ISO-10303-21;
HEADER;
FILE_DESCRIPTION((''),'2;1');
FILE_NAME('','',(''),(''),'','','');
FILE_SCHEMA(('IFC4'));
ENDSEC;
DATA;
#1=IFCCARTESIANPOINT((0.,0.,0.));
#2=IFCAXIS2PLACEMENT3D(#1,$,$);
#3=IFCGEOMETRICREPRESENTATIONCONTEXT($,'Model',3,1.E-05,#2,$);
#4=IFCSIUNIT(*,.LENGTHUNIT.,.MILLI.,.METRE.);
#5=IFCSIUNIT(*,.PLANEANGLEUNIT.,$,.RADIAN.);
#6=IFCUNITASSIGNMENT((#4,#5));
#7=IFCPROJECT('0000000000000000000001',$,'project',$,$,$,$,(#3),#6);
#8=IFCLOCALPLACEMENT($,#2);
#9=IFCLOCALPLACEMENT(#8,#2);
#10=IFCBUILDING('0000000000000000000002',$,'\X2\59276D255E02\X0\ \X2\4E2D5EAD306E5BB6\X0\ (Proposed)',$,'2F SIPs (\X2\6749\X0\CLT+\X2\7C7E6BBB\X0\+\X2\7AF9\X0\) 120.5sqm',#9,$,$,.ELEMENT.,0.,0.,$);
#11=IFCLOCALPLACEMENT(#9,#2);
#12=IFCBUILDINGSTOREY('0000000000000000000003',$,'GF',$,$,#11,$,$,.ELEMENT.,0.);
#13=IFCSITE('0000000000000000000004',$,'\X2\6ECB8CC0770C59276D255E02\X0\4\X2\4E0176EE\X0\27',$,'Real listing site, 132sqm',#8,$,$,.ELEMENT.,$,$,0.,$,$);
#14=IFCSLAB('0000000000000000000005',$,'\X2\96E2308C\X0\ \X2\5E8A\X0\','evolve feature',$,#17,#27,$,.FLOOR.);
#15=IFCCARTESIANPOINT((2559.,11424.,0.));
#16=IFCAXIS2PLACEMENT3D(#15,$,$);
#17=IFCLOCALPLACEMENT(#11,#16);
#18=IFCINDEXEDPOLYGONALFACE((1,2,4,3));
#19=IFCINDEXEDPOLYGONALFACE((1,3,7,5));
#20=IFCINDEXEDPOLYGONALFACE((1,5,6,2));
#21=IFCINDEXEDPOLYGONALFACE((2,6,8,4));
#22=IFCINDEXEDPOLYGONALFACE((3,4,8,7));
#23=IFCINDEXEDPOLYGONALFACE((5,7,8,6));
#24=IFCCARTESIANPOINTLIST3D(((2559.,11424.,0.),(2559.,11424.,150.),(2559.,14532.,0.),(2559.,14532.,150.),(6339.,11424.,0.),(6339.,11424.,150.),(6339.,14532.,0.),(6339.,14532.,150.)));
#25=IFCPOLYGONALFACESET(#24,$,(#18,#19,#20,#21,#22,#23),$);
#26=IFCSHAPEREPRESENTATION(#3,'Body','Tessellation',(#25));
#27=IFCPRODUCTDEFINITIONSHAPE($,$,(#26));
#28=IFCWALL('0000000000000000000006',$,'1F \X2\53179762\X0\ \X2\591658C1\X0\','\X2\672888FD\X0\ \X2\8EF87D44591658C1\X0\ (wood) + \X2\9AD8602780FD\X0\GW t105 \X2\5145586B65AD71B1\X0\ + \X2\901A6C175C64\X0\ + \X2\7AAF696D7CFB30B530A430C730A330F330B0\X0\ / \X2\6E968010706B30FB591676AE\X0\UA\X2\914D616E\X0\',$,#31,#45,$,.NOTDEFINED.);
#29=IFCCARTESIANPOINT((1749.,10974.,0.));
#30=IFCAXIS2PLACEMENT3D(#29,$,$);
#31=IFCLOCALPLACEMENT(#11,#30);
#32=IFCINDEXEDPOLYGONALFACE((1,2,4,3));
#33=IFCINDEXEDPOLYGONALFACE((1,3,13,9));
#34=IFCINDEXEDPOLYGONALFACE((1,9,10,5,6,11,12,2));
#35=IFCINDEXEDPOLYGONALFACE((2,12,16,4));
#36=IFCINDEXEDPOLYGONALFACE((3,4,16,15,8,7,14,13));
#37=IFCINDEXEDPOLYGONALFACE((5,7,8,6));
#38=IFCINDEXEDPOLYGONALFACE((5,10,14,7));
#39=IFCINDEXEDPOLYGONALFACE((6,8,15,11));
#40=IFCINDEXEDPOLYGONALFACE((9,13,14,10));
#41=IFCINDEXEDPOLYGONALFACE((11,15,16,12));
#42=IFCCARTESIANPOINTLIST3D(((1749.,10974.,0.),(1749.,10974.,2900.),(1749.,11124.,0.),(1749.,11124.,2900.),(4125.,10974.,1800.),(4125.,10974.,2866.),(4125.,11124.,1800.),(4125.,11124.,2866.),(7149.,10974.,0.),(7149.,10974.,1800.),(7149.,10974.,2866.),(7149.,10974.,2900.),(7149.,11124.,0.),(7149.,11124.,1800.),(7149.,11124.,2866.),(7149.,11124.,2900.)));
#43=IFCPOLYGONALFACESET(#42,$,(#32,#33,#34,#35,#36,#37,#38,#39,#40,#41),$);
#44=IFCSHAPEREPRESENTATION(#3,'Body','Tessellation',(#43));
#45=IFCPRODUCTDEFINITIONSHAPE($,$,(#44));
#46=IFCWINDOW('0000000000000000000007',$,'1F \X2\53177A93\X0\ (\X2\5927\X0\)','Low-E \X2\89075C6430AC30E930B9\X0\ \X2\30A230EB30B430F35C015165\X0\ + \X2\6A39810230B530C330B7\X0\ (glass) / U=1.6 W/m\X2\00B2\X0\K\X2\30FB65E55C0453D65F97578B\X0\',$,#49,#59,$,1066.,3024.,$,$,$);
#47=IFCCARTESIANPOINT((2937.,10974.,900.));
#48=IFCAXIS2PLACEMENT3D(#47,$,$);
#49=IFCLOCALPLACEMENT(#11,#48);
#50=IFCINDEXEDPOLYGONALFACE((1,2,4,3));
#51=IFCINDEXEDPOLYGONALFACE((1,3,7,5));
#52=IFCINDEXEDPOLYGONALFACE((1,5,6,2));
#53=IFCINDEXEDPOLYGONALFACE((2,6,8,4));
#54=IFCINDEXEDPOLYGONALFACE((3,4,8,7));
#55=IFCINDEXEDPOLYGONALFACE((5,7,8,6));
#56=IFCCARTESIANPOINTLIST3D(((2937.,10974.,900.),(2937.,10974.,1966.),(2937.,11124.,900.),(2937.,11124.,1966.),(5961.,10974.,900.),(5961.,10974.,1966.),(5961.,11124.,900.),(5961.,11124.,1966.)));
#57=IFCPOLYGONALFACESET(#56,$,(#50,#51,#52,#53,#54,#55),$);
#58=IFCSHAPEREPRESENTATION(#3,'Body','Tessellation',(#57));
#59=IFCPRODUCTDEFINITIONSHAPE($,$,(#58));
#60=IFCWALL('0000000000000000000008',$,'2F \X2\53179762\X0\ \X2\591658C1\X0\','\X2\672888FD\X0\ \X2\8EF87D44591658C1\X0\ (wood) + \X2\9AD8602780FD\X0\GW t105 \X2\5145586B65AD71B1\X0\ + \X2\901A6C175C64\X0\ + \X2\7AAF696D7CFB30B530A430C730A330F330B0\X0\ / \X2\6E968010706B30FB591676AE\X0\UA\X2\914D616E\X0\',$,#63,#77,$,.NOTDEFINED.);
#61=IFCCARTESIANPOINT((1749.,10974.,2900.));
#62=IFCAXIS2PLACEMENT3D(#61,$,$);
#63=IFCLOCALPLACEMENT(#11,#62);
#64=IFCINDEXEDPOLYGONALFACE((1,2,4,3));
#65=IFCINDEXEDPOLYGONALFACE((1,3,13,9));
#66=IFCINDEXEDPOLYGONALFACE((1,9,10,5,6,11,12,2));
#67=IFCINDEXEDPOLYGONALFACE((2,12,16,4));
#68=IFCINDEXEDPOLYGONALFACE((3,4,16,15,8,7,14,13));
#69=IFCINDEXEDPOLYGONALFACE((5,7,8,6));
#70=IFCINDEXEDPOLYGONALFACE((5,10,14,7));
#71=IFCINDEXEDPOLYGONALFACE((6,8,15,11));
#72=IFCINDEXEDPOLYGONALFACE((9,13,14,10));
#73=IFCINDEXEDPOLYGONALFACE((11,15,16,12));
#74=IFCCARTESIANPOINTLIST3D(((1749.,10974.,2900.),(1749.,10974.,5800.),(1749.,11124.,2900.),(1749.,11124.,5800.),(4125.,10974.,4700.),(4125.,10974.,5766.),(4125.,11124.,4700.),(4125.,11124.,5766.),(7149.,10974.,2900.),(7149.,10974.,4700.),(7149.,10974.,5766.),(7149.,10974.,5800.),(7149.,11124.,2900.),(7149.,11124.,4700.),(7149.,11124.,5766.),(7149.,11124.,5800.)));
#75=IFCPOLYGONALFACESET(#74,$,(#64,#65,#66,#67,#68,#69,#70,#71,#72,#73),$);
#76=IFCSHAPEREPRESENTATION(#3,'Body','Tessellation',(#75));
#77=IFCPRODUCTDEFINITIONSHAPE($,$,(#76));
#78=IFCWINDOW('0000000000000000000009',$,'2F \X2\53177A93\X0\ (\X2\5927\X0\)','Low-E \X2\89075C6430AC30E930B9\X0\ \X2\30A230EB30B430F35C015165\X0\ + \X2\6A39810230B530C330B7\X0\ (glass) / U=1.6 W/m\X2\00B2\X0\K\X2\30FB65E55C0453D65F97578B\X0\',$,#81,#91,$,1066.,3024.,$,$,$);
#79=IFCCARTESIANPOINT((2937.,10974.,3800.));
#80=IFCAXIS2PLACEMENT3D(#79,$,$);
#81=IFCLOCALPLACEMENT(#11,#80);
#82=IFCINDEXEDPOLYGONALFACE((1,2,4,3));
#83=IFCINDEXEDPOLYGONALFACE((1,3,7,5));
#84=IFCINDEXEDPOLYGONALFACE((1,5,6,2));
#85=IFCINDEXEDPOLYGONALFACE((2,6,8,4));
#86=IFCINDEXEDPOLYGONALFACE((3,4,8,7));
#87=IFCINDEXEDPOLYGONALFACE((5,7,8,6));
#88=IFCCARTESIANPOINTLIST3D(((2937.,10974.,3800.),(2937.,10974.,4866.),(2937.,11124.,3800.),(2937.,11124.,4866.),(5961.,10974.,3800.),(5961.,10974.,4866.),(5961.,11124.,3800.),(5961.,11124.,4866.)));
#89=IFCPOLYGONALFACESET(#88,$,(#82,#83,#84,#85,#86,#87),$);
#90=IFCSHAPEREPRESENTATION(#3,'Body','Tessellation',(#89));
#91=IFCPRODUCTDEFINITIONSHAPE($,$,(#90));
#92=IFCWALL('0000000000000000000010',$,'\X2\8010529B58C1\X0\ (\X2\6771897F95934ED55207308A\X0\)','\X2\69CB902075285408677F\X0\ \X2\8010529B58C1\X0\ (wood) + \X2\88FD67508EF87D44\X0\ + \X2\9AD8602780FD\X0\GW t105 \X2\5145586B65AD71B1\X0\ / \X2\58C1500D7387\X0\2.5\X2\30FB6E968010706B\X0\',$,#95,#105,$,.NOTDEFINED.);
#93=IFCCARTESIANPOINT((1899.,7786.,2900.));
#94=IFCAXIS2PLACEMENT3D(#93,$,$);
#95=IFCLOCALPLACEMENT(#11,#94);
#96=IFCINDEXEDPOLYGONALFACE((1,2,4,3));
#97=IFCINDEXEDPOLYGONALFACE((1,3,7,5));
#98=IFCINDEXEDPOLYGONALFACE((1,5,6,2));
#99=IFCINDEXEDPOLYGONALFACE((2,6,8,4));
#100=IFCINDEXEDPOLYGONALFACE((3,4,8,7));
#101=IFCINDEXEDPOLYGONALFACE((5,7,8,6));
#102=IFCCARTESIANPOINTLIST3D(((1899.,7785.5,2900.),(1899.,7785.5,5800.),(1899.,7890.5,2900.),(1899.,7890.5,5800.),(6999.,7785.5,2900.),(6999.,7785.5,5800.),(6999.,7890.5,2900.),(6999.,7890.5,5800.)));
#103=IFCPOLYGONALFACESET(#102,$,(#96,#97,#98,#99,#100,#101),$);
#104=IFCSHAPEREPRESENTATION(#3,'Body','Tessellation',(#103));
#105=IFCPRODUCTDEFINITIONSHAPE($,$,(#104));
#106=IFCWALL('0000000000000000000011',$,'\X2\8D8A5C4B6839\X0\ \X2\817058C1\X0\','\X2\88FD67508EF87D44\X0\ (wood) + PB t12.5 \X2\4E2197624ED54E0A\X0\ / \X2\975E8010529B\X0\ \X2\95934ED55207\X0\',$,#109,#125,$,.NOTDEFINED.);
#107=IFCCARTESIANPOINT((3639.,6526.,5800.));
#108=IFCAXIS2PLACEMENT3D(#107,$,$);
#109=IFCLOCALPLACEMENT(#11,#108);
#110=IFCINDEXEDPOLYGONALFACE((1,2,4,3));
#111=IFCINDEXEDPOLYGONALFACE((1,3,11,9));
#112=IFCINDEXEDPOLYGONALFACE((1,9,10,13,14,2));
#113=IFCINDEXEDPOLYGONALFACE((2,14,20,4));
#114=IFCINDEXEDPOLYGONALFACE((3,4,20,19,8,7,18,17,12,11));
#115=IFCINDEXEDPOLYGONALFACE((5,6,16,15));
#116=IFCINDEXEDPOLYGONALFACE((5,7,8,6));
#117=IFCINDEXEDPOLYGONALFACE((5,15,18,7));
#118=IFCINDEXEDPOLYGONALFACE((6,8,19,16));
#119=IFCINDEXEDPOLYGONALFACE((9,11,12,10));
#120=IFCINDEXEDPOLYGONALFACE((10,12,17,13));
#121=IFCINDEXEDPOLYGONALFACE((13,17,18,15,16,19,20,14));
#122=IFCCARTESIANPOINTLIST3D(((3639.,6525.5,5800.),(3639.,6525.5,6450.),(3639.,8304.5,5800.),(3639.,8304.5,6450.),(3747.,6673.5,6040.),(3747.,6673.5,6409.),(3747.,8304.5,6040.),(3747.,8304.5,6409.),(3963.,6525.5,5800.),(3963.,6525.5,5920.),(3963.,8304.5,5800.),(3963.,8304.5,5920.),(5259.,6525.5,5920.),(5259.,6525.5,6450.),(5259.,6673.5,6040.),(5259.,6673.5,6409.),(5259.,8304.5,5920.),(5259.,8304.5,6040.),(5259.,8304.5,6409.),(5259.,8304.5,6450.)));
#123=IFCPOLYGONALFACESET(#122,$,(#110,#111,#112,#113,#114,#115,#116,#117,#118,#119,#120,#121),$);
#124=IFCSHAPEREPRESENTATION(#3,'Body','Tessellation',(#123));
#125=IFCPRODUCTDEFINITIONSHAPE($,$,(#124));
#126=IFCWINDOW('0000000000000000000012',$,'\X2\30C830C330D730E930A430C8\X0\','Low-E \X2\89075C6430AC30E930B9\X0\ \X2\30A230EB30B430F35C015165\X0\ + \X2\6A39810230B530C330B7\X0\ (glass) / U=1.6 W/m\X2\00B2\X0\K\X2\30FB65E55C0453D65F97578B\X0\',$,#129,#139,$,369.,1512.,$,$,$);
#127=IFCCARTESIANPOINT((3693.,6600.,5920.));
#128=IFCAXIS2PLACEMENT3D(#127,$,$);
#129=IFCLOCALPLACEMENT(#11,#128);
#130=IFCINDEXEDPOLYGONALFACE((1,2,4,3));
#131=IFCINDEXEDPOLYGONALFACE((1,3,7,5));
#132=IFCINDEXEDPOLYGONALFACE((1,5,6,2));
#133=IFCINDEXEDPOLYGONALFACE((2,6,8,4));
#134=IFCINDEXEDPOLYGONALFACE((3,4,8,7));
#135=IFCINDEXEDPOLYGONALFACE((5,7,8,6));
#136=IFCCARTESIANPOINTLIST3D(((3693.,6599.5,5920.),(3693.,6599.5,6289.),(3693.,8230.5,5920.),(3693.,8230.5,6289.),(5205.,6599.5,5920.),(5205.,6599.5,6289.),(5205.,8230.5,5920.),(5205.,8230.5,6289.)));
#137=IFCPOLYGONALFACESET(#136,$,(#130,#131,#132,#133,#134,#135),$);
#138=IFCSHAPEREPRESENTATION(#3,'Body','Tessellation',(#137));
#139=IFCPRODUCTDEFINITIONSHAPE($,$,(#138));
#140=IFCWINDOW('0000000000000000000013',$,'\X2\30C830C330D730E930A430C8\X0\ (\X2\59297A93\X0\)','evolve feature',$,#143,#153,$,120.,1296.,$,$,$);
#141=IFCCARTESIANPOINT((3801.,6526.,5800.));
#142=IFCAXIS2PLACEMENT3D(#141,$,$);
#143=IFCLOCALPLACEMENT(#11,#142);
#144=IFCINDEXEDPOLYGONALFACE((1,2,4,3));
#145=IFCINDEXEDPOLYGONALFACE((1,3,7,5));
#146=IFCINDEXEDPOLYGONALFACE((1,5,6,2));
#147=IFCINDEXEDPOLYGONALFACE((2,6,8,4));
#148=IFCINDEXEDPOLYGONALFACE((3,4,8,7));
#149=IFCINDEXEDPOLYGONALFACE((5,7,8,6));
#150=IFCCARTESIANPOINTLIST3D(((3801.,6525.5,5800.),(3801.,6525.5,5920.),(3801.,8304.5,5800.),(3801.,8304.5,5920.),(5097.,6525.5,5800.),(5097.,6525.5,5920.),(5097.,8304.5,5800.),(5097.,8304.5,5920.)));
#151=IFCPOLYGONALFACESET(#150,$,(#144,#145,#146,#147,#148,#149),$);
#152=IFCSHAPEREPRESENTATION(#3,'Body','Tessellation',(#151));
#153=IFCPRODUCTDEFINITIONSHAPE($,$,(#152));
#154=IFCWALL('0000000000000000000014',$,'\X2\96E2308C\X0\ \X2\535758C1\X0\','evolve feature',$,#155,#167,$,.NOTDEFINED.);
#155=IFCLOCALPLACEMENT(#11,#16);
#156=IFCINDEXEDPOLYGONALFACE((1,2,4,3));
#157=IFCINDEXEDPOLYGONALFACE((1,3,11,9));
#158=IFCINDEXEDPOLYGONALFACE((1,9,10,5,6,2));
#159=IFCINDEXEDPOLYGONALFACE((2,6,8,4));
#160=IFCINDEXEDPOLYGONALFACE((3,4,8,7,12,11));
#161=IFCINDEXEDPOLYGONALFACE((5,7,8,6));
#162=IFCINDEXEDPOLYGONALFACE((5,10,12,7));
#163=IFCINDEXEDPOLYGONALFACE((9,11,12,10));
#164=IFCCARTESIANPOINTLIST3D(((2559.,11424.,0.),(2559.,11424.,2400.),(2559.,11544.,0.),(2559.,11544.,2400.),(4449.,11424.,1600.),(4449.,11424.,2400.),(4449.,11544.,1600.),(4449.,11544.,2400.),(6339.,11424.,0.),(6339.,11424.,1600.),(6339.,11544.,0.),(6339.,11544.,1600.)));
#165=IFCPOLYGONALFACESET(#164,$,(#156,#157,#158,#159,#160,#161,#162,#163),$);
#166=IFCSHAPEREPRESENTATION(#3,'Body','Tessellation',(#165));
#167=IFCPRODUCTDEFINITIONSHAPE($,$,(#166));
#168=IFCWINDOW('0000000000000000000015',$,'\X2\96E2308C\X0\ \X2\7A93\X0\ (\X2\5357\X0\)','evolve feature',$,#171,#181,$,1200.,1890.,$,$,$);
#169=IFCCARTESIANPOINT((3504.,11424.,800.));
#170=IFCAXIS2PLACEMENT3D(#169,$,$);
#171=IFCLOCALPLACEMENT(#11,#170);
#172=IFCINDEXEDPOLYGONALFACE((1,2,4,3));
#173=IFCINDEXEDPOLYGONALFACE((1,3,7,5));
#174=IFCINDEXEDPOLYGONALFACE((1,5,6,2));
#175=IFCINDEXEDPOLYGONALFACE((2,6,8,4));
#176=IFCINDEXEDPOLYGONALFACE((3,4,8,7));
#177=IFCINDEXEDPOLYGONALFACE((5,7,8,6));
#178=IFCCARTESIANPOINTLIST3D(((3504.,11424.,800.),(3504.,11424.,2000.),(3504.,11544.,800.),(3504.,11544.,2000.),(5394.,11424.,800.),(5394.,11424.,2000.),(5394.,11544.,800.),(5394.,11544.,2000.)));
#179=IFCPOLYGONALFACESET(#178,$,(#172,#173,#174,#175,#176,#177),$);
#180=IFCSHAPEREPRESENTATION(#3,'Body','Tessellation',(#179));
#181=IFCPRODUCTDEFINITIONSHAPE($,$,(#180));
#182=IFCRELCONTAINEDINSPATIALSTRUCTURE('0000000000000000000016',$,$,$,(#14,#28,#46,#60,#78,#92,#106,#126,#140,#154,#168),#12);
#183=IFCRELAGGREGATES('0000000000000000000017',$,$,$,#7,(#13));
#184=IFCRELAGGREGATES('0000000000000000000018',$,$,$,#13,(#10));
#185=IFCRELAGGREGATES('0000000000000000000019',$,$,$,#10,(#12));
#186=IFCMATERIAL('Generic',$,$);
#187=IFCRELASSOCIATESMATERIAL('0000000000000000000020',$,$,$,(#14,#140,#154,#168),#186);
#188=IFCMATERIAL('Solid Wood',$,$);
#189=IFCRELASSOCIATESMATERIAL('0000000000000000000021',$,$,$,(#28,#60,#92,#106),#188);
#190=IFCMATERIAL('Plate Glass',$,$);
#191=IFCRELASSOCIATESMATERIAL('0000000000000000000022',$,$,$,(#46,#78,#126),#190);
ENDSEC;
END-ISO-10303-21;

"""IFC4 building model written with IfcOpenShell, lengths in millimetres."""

from ifc_helpers import new_model, si_unit, frame, frame_2d, origin, place, context, project, spatial, rectangle, extrude, material, element, fill, save


model = new_model("IFC4")

# Units and contexts
model_context = context("Model", 3, precision=1e-05, world=origin())
ifc_project = project(units=[si_unit("LENGTHUNIT", "METRE", prefix="MILLI"), si_unit("PLANEANGLEUNIT", "RADIAN")], contexts=[model_context])

# Site, building, storey
site_placement = place(None, origin())
site = spatial("IfcSite", under=ifc_project, at=site_placement, Name="滋賀県大津市4丁目27", ObjectType="Real listing site, 132sqm", CompositionType="ELEMENT", RefElevation=0.0)
building_placement = place(site_placement, origin())
building = spatial("IfcBuilding", under=site, at=building_placement, Name="大津市 中庭の家 (Proposed)", ObjectType="2F SIPs (杉CLT+籾殻+竹) 120.5sqm", CompositionType="ELEMENT", ElevationOfRefHeight=0.0, ElevationOfTerrain=0.0)
storey_placement = place(building_placement, origin())
storey = spatial("IfcBuildingStorey", under=building, at=storey_placement, Name="GF", CompositionType="ELEMENT", Elevation=0.0)

# Slab
ifc_material_1 = material(Name="Generic")
slab_placement = place(storey_placement, frame((2559.0, 11424.0, 0.0)))
element("IfcSlab", 1, at=slab_placement, inside=storey, material=ifc_material_1, Name="離れ 床", Description="evolve feature", PredefinedType="FLOOR", context=model_context, shape_type="SweptSolid", body=[
    extrude(rectangle(XDim=3780.0, YDim=3108.0, at=frame_2d((1890.0, 1554.0))), frame((2559.0, 11424.0, 0.0)), (0.0, 0.0, 1.0), 150.0),
])

# Wall, opening, window
ifc_material_2 = material(Name="Solid Wood")
wall_1_placement = place(storey_placement, frame((1749.0, 10974.0, 0.0)))
wall_1 = element("IfcWall", 2, at=wall_1_placement, inside=storey, material=ifc_material_2, Name="1F 北面 外壁", Description="木製 軸組外壁 (wood) + 高性能GW t105 充填断熱 + 通気層 + 窯業系サイディング / 準耐火・外皮UA配慮", PredefinedType="NOTDEFINED", context=model_context, shape_type="SweptSolid", body=[
    extrude(rectangle(XDim=5400.0, YDim=150.0, at=frame_2d((2700.0, 75.0))), frame((1749.0, 10974.0, 0.0)), (0.0, 0.0, 1.0), 2900.0),
])
opening_1_placement = place(storey_placement, frame((2937.0, 10974.0, 900.0)))
opening_1 = element("IfcOpeningElement", 3, at=opening_1_placement, cuts=wall_1, PredefinedType="NOTDEFINED", context=model_context, shape_type="SweptSolid", body=[
    extrude(rectangle(XDim=3024.0, YDim=150.0, at=frame_2d((1512.0, 75.0))), frame((2937.0, 10974.0, 900.0)), (0.0, 0.0, 1.0), 1066.0),
])
ifc_material_3 = material(Name="Plate Glass")
window_1_placement = place(storey_placement, frame((2937.0, 10974.0, 900.0)))
window_1 = element("IfcWindow", 4, at=window_1_placement, inside=storey, material=ifc_material_3, Name="1F 北窓 (大)", Description="Low-E 複層ガラス アルゴン封入 + 樹脂サッシ (glass) / U=1.6 W/m²K・日射取得型", OverallHeight=1066.0, OverallWidth=3024.0, context=model_context, shape_type="SweptSolid", body=[
    extrude(rectangle(XDim=3024.0, YDim=150.0, at=frame_2d((1512.0, 75.0))), frame((2937.0, 10974.0, 900.0)), (0.0, 0.0, 1.0), 1066.0),
])
fill(opening_1, window_1)

# Wall, opening, window
wall_2_placement = place(storey_placement, frame((1749.0, 10974.0, 2900.0)))
wall_2 = element("IfcWall", 5, at=wall_2_placement, inside=storey, material=ifc_material_2, Name="2F 北面 外壁", Description="木製 軸組外壁 (wood) + 高性能GW t105 充填断熱 + 通気層 + 窯業系サイディング / 準耐火・外皮UA配慮", PredefinedType="NOTDEFINED", context=model_context, shape_type="SweptSolid", body=[
    extrude(rectangle(XDim=5400.0, YDim=150.0, at=frame_2d((2700.0, 75.0))), frame((1749.0, 10974.0, 2900.0)), (0.0, 0.0, 1.0), 2900.0),
])
opening_2_placement = place(storey_placement, frame((2937.0, 10974.0, 3800.0)))
opening_2 = element("IfcOpeningElement", 6, at=opening_2_placement, cuts=wall_2, PredefinedType="NOTDEFINED", context=model_context, shape_type="SweptSolid", body=[
    extrude(rectangle(XDim=3024.0, YDim=150.0, at=frame_2d((1512.0, 75.0))), frame((2937.0, 10974.0, 3800.0)), (0.0, 0.0, 1.0), 1066.0),
])
window_2_placement = place(storey_placement, frame((2937.0, 10974.0, 3800.0)))
window_2 = element("IfcWindow", 7, at=window_2_placement, inside=storey, material=ifc_material_3, Name="2F 北窓 (大)", Description="Low-E 複層ガラス アルゴン封入 + 樹脂サッシ (glass) / U=1.6 W/m²K・日射取得型", OverallHeight=1066.0, OverallWidth=3024.0, context=model_context, shape_type="SweptSolid", body=[
    extrude(rectangle(XDim=3024.0, YDim=150.0, at=frame_2d((1512.0, 75.0))), frame((2937.0, 10974.0, 3800.0)), (0.0, 0.0, 1.0), 1066.0),
])
fill(opening_2, window_2)

# Wall
wall_3_placement = place(storey_placement, frame((1899.0, 7786.0, 2900.0)))
element("IfcWall", 8, at=wall_3_placement, inside=storey, material=ifc_material_2, Name="耐力壁 (東西間仕切り)", Description="構造用合板 耐力壁 (wood) + 製材軸組 + 高性能GW t105 充填断熱 / 壁倍率2.5・準耐火", PredefinedType="NOTDEFINED", context=model_context, shape_type="SweptSolid", body=[
    extrude(rectangle(XDim=5100.0, YDim=105.0, at=frame_2d((2550.0, 52.0))), frame((1899.0, 7786.0, 2900.0)), (0.0, 0.0, 1.0), 2900.0),
])

# Wall, openings, windows
wall_4_placement = place(storey_placement, frame((3639.0, 6526.0, 5800.0)))
wall_4 = element("IfcWall", 9, at=wall_4_placement, inside=storey, material=ifc_material_2, Name="越屋根 腰壁", Description="製材軸組 (wood) + PB t12.5 両面仕上 / 非耐力 間仕切", PredefinedType="NOTDEFINED", context=model_context, shape_type="SweptSolid", body=[
    extrude(rectangle(XDim=1620.0, YDim=1779.0, at=frame_2d((810.0, 889.0))), frame((3639.0, 6526.0, 5800.0)), (0.0, 0.0, 1.0), 650.0),
])
opening_3_placement = place(storey_placement, frame((3693.0, 6600.0, 5920.0)))
opening_3 = element("IfcOpeningElement", 10, at=opening_3_placement, cuts=wall_4, PredefinedType="NOTDEFINED", context=model_context, shape_type="SweptSolid", body=[
    extrude(rectangle(XDim=1512.0, YDim=1631.0, at=frame_2d((756.0, 815.0))), frame((3693.0, 6600.0, 5920.0)), (0.0, 0.0, 1.0), 369.0),
])
opening_4_placement = place(storey_placement, frame((3801.0, 6526.0, 5800.0)))
opening_4 = element("IfcOpeningElement", 11, at=opening_4_placement, cuts=wall_4, PredefinedType="NOTDEFINED", context=model_context, shape_type="SweptSolid", body=[
    extrude(rectangle(XDim=1296.0, YDim=1779.0, at=frame_2d((648.0, 889.0))), frame((3801.0, 6526.0, 5800.0)), (0.0, 0.0, 1.0), 120.0),
])
window_3_placement = place(storey_placement, frame((3693.0, 6600.0, 5920.0)))
window_3 = element("IfcWindow", 12, at=window_3_placement, inside=storey, material=ifc_material_3, Name="トップライト", Description="Low-E 複層ガラス アルゴン封入 + 樹脂サッシ (glass) / U=1.6 W/m²K・日射取得型", OverallHeight=369.0, OverallWidth=1512.0, context=model_context, shape_type="SweptSolid", body=[
    extrude(rectangle(XDim=1512.0, YDim=1631.0, at=frame_2d((756.0, 815.0))), frame((3693.0, 6600.0, 5920.0)), (0.0, 0.0, 1.0), 369.0),
])
fill(opening_3, window_3)
window_4_placement = place(storey_placement, frame((3801.0, 6526.0, 5800.0)))
window_4 = element("IfcWindow", 13, at=window_4_placement, inside=storey, material=ifc_material_1, Name="トップライト (天窓)", Description="evolve feature", OverallHeight=120.0, OverallWidth=1296.0, context=model_context, shape_type="SweptSolid", body=[
    extrude(rectangle(XDim=1296.0, YDim=1779.0, at=frame_2d((648.0, 889.0))), frame((3801.0, 6526.0, 5800.0)), (0.0, 0.0, 1.0), 120.0),
])
fill(opening_4, window_4)

# Wall, opening, window
wall_5_placement = place(storey_placement, frame((2559.0, 11424.0, 0.0)))
wall_5 = element("IfcWall", 14, at=wall_5_placement, inside=storey, material=ifc_material_1, Name="離れ 南壁", Description="evolve feature", PredefinedType="NOTDEFINED", context=model_context, shape_type="SweptSolid", body=[
    extrude(rectangle(XDim=3780.0, YDim=120.0, at=frame_2d((1890.0, 60.0))), frame((2559.0, 11424.0, 0.0)), (0.0, 0.0, 1.0), 2400.0),
])
opening_5_placement = place(storey_placement, frame((3504.0, 11424.0, 800.0)))
opening_5 = element("IfcOpeningElement", 15, at=opening_5_placement, cuts=wall_5, PredefinedType="NOTDEFINED", context=model_context, shape_type="SweptSolid", body=[
    extrude(rectangle(XDim=1890.0, YDim=120.0, at=frame_2d((945.0, 60.0))), frame((3504.0, 11424.0, 800.0)), (0.0, 0.0, 1.0), 1200.0),
])
window_5_placement = place(storey_placement, frame((3504.0, 11424.0, 800.0)))
window_5 = element("IfcWindow", 16, at=window_5_placement, inside=storey, material=ifc_material_1, Name="離れ 窓 (南)", Description="evolve feature", OverallHeight=1200.0, OverallWidth=1890.0, context=model_context, shape_type="SweptSolid", body=[
    extrude(rectangle(XDim=1890.0, YDim=120.0, at=frame_2d((945.0, 60.0))), frame((3504.0, 11424.0, 800.0)), (0.0, 0.0, 1.0), 1200.0),
])
fill(opening_5, window_5)

save(model, "model.ifc")
